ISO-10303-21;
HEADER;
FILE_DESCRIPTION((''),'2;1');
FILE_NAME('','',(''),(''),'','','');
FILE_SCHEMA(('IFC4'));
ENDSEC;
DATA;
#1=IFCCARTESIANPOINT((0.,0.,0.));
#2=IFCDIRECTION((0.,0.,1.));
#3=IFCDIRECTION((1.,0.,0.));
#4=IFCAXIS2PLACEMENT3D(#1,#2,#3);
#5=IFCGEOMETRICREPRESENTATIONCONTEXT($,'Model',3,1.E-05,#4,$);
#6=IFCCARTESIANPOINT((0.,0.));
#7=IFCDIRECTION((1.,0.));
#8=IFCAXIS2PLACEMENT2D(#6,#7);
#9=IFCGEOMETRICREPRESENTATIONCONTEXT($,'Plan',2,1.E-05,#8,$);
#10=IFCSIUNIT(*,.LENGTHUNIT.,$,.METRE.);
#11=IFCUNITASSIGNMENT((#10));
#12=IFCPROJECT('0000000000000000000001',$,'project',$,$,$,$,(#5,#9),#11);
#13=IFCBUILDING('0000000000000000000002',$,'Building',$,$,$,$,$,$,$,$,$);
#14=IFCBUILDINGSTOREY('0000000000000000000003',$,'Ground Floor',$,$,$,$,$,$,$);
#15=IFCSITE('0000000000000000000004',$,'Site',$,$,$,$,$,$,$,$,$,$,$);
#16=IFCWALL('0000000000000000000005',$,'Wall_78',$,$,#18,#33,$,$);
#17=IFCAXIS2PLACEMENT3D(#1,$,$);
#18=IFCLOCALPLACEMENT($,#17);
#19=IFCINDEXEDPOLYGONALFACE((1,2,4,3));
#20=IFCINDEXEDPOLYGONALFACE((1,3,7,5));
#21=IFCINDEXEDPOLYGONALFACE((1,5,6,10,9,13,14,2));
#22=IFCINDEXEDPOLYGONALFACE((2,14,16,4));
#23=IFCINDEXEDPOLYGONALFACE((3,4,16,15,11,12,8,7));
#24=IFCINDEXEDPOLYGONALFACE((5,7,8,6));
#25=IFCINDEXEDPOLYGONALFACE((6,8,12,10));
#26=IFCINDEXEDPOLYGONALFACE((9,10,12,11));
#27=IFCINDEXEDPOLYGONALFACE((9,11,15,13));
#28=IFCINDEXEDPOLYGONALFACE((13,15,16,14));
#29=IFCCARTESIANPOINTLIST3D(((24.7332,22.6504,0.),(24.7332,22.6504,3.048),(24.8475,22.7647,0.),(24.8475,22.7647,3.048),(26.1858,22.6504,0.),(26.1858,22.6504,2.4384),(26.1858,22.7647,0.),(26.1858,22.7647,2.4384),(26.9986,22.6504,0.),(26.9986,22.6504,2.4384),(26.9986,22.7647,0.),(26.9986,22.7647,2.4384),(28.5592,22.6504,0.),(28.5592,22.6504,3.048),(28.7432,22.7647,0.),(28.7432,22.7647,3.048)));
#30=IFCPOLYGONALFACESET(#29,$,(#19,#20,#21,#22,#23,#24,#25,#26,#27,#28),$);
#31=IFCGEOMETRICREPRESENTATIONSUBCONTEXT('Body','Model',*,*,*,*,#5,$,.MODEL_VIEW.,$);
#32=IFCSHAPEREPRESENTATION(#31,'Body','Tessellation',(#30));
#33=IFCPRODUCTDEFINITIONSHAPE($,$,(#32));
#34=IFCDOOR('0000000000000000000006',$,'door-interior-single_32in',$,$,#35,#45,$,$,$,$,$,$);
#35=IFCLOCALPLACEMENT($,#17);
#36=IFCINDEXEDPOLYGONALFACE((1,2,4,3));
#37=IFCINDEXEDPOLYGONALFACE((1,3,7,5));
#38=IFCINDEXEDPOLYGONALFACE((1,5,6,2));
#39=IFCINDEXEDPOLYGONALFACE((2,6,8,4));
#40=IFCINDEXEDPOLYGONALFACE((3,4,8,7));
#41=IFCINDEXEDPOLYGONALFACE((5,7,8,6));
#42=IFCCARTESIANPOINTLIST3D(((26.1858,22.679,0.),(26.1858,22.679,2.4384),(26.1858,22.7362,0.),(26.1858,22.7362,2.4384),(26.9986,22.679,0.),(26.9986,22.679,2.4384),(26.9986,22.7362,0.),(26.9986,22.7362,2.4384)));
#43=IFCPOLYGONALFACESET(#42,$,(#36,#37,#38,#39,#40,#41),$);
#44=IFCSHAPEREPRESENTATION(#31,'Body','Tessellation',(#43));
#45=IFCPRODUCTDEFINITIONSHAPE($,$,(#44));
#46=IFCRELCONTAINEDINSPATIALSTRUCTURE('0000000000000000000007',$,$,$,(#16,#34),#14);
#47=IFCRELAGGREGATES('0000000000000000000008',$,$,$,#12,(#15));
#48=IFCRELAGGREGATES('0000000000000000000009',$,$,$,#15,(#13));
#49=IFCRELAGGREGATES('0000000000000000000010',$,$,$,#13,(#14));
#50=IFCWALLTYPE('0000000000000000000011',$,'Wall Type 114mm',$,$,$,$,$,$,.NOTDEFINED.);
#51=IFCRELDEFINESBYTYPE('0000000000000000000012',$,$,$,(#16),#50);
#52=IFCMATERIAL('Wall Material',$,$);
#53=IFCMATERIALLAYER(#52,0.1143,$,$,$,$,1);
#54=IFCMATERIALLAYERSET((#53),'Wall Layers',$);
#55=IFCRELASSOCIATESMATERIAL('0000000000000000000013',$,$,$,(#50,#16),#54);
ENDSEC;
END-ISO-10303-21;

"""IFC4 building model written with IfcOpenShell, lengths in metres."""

from ifc_helpers import new_model, si_unit, frame, origin_with_axes, origin_2d_with_axis, place, context, subcontext, project, spatial, line, indexed_curve, rectangle, outline, extrude, material, layer, layer_set, layer_usage, type_object, element, fill, save


model = new_model("IFC4")

# Units and contexts
model_context = context("Model", 3, precision=1e-05, world=origin_with_axes())
plan_context = context("Plan", 2, precision=1e-05, world=origin_2d_with_axis())
body_context = subcontext(model_context, "Body", "Model", "MODEL_VIEW")
ifc_project = project(units=[si_unit("LENGTHUNIT", "METRE")], contexts=[model_context, plan_context])

# Site, building, storey
site = spatial("IfcSite", under=ifc_project, Name="Site")
building = spatial("IfcBuilding", under=site, Name="Building")
storey = spatial("IfcBuildingStorey", under=building, Name="Ground Floor")

# Shared definitions
ifc_material_1 = material(Name="Wall Material")
ifc_layer_1 = layer(ifc_material_1, 0.1143, Priority=1)
ifc_layer_set_1 = layer_set([ifc_layer_1], Name="Wall Layers")
wall_type_1 = type_object("IfcWallType", Name="Wall Type 114mm", PredefinedType="NOTDEFINED", material=ifc_layer_set_1)

# Wall, opening, door
ifc_layer_usage_1 = layer_usage(ifc_layer_set_1, "AXIS2", "POSITIVE", -0.0571)
wall_1_placement = place(None, frame((28.6512, 22.7076, 0.0), z_axis=(0.0, 0.0, 1.0), x_axis=(-1.0, 0.0, 0.0)))
wall_1 = element("IfcWall", 1, at=wall_1_placement, inside=storey, type_object=wall_type_1, material=ifc_layer_usage_1, Name="Wall_78", context=body_context, shape_type="SweptSolid", body=[
    extrude(outline(indexed_curve([(-0.092, -0.0571), (0.092, 0.0571), (3.918, 0.0571), (3.8037, -0.0571)], segments=[line(1, 2, 3, 4, 1)])), origin_with_axes(), (0.0, 0.0, 1.0), 3.048),
])
opening_1_placement = place(wall_1_placement, frame((2.059, 0.0, 0.0), z_axis=(0.0, 0.0, 1.0), x_axis=(1.0, 0.0, 0.0)))
opening_1 = element("IfcOpeningElement", 2, at=opening_1_placement, cuts=wall_1, context=body_context, shape_type="SweptSolid", body=[
    extrude(rectangle(XDim=0.8128, YDim=0.5), None, (0.0, 0.0, 1.0), 2.4384),
])
door_1_placement = place(None, frame((26.5922, 22.7076, 0.0), z_axis=(0.0, 0.0, 1.0), x_axis=(1.0, 0.0, 0.0)))
door_1 = element("IfcDoor", 3, at=door_1_placement, inside=storey, Name="door-interior-single_32in", context=body_context, shape_type="SweptSolid", body=[
    extrude(rectangle(XDim=0.8128, YDim=0.0571), None, (0.0, 0.0, 1.0), 2.4384),
])
fill(opening_1, door_1)

save(model, "model.ifc")
